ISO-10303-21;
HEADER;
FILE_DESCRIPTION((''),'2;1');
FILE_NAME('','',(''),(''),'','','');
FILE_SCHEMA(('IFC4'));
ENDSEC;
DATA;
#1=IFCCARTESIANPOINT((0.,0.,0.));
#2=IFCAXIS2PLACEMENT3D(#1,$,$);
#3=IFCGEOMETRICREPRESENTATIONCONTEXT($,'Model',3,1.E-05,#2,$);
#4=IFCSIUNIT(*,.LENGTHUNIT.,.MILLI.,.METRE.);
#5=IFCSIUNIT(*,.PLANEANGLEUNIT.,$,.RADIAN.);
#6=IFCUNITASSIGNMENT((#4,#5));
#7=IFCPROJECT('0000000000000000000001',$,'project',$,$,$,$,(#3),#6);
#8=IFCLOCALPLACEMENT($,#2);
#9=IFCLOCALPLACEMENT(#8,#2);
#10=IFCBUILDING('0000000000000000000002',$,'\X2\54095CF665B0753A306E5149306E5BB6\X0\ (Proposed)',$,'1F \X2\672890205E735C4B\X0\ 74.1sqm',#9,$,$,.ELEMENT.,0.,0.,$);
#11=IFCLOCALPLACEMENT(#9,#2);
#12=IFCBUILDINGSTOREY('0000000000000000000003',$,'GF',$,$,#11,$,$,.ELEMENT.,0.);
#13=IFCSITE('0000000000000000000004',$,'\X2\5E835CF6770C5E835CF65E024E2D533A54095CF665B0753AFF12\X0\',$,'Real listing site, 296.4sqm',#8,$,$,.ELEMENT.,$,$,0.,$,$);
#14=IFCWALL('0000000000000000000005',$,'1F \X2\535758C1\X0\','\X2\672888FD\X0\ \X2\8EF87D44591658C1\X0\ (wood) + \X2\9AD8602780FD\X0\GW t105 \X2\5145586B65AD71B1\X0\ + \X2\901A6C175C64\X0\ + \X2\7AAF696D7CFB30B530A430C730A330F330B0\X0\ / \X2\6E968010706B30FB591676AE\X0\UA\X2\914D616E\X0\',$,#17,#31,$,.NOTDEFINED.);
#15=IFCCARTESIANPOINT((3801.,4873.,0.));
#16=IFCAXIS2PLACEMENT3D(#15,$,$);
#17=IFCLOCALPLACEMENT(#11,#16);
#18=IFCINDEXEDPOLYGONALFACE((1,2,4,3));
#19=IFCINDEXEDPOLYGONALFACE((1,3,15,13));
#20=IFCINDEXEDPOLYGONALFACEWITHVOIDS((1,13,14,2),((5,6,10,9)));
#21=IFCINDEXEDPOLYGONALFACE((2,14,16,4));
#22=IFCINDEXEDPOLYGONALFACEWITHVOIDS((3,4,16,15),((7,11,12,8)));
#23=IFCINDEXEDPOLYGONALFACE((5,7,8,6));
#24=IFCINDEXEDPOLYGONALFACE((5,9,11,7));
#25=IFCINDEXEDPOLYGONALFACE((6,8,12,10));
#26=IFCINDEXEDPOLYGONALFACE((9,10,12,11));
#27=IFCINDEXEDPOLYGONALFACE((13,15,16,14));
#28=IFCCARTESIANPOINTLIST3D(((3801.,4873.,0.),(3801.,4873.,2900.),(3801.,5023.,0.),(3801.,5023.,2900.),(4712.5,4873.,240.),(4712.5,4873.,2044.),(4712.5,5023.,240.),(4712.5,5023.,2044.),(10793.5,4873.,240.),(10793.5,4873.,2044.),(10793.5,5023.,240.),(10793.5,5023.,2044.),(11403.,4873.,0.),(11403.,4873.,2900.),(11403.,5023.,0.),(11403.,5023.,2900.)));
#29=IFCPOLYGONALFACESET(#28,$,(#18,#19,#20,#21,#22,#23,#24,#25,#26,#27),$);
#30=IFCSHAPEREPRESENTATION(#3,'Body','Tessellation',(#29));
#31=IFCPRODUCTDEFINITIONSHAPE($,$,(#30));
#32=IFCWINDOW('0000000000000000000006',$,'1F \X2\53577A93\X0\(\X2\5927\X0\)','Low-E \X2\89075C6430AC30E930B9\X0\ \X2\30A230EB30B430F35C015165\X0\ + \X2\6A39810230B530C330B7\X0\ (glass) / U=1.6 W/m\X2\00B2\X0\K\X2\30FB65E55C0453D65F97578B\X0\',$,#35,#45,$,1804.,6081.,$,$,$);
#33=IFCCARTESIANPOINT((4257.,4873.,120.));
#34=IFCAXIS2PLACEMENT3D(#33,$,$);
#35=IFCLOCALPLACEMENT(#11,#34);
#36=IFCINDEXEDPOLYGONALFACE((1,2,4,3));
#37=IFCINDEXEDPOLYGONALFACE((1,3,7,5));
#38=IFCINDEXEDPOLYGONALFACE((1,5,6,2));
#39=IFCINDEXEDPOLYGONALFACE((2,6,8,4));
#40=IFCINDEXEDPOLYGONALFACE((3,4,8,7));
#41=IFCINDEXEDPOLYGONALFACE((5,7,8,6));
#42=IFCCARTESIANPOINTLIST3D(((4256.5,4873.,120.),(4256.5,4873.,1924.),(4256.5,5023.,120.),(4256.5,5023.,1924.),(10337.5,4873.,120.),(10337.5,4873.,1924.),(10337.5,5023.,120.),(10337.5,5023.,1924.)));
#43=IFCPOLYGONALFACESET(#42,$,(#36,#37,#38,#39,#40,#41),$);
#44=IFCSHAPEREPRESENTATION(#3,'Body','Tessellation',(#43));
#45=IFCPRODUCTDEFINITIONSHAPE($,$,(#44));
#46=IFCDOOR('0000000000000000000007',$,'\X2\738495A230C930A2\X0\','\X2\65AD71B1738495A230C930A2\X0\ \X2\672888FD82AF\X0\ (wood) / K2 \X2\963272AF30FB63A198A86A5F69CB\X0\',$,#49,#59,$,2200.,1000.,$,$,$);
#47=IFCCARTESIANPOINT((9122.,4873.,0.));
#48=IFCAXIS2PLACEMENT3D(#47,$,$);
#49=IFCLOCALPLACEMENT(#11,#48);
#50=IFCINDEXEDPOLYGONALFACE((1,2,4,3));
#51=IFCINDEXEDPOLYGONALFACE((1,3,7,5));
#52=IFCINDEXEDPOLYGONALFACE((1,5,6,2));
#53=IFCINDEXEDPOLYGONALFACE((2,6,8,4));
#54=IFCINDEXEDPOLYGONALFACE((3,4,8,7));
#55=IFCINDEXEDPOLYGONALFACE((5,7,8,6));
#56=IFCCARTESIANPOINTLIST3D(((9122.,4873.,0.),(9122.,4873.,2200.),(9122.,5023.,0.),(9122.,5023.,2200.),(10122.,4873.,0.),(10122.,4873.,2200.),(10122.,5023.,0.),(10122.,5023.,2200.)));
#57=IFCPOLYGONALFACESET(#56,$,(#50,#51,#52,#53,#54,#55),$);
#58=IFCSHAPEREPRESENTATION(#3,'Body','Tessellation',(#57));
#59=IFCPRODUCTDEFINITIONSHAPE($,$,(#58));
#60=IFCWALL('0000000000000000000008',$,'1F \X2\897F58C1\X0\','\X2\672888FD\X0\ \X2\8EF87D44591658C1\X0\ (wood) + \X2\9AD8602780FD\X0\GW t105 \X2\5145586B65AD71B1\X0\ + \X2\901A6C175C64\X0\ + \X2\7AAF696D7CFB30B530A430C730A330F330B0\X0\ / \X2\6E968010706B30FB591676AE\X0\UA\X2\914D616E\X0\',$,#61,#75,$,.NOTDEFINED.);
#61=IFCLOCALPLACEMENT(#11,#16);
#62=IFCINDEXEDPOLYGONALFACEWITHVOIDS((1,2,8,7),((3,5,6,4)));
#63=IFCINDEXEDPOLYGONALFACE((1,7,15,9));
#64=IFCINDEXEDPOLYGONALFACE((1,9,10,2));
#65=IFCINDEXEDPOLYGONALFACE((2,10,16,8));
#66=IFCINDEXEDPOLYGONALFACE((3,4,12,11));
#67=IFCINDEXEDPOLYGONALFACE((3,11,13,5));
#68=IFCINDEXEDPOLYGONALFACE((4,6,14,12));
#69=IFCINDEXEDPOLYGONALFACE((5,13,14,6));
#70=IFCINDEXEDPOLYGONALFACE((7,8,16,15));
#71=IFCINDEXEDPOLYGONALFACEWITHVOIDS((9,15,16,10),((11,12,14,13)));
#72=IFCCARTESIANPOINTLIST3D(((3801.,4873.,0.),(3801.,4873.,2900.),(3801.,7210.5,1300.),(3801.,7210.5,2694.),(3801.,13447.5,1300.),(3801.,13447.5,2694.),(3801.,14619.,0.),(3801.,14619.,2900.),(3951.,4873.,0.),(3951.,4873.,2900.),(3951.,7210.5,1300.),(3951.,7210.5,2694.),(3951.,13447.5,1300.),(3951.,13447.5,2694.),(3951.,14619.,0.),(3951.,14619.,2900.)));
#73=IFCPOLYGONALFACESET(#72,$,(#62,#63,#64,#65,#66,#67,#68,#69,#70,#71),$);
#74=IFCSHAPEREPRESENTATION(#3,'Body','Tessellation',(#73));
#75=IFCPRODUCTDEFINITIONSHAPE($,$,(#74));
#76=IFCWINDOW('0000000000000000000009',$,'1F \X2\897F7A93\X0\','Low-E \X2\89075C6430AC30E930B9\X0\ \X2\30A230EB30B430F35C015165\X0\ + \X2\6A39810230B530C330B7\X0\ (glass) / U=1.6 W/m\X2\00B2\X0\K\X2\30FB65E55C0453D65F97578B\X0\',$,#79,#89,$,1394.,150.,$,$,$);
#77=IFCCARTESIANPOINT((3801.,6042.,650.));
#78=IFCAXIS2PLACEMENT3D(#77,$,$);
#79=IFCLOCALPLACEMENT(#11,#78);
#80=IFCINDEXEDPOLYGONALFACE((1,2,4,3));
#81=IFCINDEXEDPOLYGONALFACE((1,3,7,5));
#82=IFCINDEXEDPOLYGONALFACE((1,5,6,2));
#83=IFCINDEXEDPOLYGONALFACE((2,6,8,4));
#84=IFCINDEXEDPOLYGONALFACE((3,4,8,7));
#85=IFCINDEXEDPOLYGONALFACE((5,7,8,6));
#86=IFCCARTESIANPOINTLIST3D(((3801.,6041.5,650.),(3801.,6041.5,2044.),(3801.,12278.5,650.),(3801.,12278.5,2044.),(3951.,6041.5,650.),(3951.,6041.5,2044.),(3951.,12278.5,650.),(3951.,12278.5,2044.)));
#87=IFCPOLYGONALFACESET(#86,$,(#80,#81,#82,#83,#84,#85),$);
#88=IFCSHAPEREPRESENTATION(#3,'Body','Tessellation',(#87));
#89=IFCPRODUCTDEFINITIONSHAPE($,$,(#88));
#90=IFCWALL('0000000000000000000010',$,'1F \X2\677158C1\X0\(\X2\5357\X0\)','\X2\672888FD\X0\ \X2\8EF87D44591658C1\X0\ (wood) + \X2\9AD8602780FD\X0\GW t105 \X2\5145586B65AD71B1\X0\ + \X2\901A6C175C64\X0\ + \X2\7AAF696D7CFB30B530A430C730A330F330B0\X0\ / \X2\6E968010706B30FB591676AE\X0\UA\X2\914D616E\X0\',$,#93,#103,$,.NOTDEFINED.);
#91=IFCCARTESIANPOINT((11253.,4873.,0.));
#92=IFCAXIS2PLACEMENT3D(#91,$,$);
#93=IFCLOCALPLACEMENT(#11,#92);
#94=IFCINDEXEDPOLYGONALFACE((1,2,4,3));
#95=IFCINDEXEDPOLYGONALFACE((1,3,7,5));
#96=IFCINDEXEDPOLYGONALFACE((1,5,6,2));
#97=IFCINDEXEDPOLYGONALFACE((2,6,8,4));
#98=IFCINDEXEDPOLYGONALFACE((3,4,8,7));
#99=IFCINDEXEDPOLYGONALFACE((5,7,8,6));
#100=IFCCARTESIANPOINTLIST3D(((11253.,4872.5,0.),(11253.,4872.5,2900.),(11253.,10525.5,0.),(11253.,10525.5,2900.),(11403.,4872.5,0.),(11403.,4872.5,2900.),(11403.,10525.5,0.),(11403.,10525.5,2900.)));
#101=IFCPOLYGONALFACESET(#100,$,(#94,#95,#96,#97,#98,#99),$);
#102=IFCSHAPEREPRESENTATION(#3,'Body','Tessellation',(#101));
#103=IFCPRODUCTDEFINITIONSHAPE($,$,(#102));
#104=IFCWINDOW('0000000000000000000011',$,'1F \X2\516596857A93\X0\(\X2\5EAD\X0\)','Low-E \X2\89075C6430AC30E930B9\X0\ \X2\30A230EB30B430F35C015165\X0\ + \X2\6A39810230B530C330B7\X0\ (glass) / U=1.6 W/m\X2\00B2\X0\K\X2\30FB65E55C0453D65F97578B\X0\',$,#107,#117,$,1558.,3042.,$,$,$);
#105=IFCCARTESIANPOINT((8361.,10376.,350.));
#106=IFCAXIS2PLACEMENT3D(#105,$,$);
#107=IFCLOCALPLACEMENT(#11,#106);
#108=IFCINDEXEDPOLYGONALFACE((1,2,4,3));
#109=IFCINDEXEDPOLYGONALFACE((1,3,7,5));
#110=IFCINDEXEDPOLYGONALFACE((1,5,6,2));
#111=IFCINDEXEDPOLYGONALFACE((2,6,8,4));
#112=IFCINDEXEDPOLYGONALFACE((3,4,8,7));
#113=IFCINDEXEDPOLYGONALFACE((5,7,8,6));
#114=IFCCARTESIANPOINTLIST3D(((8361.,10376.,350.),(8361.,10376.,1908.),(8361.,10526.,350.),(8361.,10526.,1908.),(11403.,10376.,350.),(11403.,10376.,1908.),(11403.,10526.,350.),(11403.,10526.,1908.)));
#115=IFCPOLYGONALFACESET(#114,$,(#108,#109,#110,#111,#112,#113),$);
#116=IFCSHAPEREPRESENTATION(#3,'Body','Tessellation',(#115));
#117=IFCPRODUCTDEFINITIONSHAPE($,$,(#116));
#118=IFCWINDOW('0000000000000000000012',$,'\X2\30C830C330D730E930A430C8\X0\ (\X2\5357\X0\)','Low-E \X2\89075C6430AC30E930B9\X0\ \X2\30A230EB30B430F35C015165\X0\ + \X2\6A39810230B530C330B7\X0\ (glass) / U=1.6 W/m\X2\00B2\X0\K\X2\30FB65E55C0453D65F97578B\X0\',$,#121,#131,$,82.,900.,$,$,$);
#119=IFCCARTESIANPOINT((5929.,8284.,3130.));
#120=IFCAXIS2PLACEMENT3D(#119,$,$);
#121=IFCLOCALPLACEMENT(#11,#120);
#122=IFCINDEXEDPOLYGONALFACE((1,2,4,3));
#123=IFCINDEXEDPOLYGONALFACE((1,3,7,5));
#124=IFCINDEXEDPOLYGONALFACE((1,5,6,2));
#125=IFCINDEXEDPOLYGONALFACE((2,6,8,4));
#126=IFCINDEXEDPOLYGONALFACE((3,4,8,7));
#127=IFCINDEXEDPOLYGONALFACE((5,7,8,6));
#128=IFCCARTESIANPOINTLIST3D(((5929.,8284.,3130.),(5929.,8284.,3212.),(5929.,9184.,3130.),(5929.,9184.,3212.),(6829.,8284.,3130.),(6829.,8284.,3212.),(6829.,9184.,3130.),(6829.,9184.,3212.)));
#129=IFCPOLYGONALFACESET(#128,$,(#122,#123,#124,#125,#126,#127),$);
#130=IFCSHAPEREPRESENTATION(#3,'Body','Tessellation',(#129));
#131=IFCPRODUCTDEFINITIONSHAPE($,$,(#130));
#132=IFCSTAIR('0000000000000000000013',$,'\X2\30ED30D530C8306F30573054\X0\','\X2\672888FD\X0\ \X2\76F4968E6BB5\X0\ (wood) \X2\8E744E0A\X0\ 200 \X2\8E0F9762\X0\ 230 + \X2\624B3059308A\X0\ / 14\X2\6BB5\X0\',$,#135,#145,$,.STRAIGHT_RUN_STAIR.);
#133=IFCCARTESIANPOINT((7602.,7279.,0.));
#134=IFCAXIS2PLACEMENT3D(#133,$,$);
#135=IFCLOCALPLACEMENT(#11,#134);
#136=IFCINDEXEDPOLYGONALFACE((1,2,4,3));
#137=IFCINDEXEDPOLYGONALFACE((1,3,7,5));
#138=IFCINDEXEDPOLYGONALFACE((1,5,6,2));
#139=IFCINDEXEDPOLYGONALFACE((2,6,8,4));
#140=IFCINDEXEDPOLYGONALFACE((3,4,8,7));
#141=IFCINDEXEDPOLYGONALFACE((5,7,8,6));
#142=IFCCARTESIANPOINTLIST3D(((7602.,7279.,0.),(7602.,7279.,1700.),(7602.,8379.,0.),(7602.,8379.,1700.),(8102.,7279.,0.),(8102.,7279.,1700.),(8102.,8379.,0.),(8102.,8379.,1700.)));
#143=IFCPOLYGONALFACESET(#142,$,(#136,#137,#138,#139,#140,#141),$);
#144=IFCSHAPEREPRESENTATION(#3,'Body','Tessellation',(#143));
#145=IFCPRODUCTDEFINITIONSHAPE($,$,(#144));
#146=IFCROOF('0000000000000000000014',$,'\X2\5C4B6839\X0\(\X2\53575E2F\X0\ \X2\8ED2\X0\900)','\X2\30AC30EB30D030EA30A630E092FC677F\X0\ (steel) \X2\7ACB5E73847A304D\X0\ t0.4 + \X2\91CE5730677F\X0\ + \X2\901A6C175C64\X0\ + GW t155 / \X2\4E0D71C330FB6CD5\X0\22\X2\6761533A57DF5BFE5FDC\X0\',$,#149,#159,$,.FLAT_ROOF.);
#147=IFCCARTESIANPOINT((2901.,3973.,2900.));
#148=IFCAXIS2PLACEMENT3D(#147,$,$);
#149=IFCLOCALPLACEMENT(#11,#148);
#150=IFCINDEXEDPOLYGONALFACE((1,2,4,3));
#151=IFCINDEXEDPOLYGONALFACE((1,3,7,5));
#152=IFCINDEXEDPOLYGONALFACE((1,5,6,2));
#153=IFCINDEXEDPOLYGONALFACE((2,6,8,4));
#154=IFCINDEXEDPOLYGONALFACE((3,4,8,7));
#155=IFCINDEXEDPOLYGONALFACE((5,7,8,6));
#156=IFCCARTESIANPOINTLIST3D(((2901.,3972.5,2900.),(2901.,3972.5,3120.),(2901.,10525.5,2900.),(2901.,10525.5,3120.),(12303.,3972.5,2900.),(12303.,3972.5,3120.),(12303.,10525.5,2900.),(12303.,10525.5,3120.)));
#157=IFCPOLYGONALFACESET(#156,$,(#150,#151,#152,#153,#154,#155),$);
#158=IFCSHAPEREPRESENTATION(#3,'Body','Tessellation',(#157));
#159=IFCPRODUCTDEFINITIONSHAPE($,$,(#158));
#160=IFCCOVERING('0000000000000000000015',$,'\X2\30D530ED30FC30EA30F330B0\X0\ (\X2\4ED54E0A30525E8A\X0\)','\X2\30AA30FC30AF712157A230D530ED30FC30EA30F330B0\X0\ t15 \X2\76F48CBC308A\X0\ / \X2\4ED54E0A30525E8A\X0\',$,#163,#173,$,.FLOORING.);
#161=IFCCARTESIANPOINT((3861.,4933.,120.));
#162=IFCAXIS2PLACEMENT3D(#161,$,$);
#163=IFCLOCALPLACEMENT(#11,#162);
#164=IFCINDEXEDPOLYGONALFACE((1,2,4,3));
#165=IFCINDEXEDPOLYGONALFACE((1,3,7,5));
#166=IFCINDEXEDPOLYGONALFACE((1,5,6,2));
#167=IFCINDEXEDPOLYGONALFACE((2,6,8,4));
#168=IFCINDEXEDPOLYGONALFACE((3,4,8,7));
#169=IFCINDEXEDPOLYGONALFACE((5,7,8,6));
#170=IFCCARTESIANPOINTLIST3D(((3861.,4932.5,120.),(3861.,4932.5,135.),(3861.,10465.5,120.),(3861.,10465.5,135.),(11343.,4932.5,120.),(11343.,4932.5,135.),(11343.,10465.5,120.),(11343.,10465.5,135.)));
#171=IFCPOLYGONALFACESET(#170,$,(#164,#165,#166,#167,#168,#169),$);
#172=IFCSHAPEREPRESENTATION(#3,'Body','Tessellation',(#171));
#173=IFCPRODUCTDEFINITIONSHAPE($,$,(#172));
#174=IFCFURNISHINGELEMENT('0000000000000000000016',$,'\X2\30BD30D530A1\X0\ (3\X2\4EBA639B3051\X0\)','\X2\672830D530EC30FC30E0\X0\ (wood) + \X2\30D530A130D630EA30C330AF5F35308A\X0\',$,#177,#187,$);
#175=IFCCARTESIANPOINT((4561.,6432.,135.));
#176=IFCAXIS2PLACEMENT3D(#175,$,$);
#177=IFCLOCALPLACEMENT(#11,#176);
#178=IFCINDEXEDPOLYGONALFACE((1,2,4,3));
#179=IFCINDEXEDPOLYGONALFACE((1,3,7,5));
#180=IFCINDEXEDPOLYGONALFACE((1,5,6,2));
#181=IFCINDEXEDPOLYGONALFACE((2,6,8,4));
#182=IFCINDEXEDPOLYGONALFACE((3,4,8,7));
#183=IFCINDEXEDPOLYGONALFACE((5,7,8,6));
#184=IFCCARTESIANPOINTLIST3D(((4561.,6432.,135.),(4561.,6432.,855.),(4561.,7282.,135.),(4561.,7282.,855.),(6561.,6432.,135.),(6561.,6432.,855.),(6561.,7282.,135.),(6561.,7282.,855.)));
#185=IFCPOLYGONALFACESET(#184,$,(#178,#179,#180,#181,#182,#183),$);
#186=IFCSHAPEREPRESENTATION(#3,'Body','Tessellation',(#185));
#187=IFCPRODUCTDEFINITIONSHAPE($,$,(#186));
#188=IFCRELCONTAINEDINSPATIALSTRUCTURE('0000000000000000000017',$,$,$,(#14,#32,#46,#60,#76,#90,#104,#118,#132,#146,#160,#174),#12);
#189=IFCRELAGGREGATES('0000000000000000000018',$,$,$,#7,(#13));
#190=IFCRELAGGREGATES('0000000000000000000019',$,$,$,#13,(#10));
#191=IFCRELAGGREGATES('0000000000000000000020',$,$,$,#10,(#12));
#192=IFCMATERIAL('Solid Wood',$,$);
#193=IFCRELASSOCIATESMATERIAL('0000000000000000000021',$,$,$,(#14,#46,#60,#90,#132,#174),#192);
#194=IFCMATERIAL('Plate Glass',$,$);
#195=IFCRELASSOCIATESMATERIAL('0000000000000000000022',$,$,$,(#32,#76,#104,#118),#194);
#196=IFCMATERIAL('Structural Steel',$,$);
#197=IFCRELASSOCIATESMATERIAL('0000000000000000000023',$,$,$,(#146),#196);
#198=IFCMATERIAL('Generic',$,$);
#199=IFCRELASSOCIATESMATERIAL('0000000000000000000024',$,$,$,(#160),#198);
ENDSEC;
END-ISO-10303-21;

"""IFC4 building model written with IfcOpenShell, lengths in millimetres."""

from ifc_helpers import new_model, si_unit, frame, frame_2d, origin, place, context, project, spatial, rectangle, extrude, material, element, fill, save


model = new_model("IFC4")

# Units and contexts
model_context = context("Model", 3, precision=1e-05, world=origin())
ifc_project = project(units=[si_unit("LENGTHUNIT", "METRE", prefix="MILLI"), si_unit("PLANEANGLEUNIT", "RADIAN")], contexts=[model_context])

# Site, building, storey
site_placement = place(None, origin())
site = spatial("IfcSite", under=ifc_project, at=site_placement, Name="広島県広島市中区吉島新町２", ObjectType="Real listing site, 296.4sqm", CompositionType="ELEMENT", RefElevation=0.0)
building_placement = place(site_placement, origin())
building = spatial("IfcBuilding", under=site, at=building_placement, Name="吉島新町の光の家 (Proposed)", ObjectType="1F 木造平屋 74.1sqm", CompositionType="ELEMENT", ElevationOfRefHeight=0.0, ElevationOfTerrain=0.0)
storey_placement = place(building_placement, origin())
storey = spatial("IfcBuildingStorey", under=building, at=storey_placement, Name="GF", CompositionType="ELEMENT", Elevation=0.0)

# Shared definitions
ifc_material_1 = material(Name="Solid Wood")

# Wall, openings, window, door
wall_1_placement = place(storey_placement, frame((3801.0, 4873.0, 0.0)))
wall_1 = element("IfcWall", 1, at=wall_1_placement, inside=storey, material=ifc_material_1, Name="1F 南壁", Description="木製 軸組外壁 (wood) + 高性能GW t105 充填断熱 + 通気層 + 窯業系サイディング / 準耐火・外皮UA配慮", PredefinedType="NOTDEFINED", context=model_context, shape_type="SweptSolid", body=[
    extrude(rectangle(XDim=7602.0, YDim=150.0, at=frame_2d((3801.0, 75.0))), frame((3801.0, 4873.0, 0.0)), (0.0, 0.0, 1.0), 2900.0),
])
opening_1_placement = place(storey_placement, frame((4257.0, 4873.0, 120.0)))
opening_1 = element("IfcOpeningElement", 2, at=opening_1_placement, cuts=wall_1, PredefinedType="NOTDEFINED", context=model_context, shape_type="SweptSolid", body=[
    extrude(rectangle(XDim=6081.0, YDim=150.0, at=frame_2d((3040.0, 75.0))), frame((4257.0, 4873.0, 120.0)), (0.0, 0.0, 1.0), 1804.0),
])
opening_2_placement = place(storey_placement, frame((9122.0, 4873.0, 0.0)))
opening_2 = element("IfcOpeningElement", 3, at=opening_2_placement, cuts=wall_1, PredefinedType="NOTDEFINED", context=model_context, shape_type="SweptSolid", body=[
    extrude(rectangle(XDim=1000.0, YDim=150.0, at=frame_2d((500.0, 75.0))), frame((9122.0, 4873.0, 0.0)), (0.0, 0.0, 1.0), 2200.0),
])
ifc_material_2 = material(Name="Plate Glass")
window_1_placement = place(storey_placement, frame((4257.0, 4873.0, 120.0)))
window_1 = element("IfcWindow", 4, at=window_1_placement, inside=storey, material=ifc_material_2, Name="1F 南窓(大)", Description="Low-E 複層ガラス アルゴン封入 + 樹脂サッシ (glass) / U=1.6 W/m²K・日射取得型", OverallHeight=1804.0, OverallWidth=6081.0, context=model_context, shape_type="SweptSolid", body=[
    extrude(rectangle(XDim=6081.0, YDim=150.0, at=frame_2d((3040.0, 75.0))), frame((4257.0, 4873.0, 120.0)), (0.0, 0.0, 1.0), 1804.0),
])
fill(opening_1, window_1)
door_1_placement = place(storey_placement, frame((9122.0, 4873.0, 0.0)))
door_1 = element("IfcDoor", 5, at=door_1_placement, inside=storey, material=ifc_material_1, Name="玄関ドア", Description="断熱玄関ドア 木製芯 (wood) / K2 防犯・採風機構", OverallHeight=2200.0, OverallWidth=1000.0, context=model_context, shape_type="SweptSolid", body=[
    extrude(rectangle(XDim=1000.0, YDim=150.0, at=frame_2d((500.0, 75.0))), frame((9122.0, 4873.0, 0.0)), (0.0, 0.0, 1.0), 2200.0),
])
fill(opening_2, door_1)

# Walls, openings, windows
wall_2_placement = place(storey_placement, frame((3801.0, 4873.0, 0.0)))
wall_2 = element("IfcWall", 6, at=wall_2_placement, inside=storey, material=ifc_material_1, Name="1F 西壁", Description="木製 軸組外壁 (wood) + 高性能GW t105 充填断熱 + 通気層 + 窯業系サイディング / 準耐火・外皮UA配慮", PredefinedType="NOTDEFINED", context=model_context, shape_type="SweptSolid", body=[
    extrude(rectangle(XDim=150.0, YDim=9746.0, at=frame_2d((75.0, 4873.0))), frame((3801.0, 4873.0, 0.0)), (0.0, 0.0, 1.0), 2900.0),
])
opening_3_placement = place(storey_placement, frame((3801.0, 6042.0, 650.0)))
opening_3 = element("IfcOpeningElement", 7, at=opening_3_placement, cuts=wall_2, PredefinedType="NOTDEFINED", context=model_context, shape_type="SweptSolid", body=[
    extrude(rectangle(XDim=150.0, YDim=6237.0, at=frame_2d((75.0, 3118.0))), frame((3801.0, 6042.0, 650.0)), (0.0, 0.0, 1.0), 1394.0),
])
window_2_placement = place(storey_placement, frame((3801.0, 6042.0, 650.0)))
window_2 = element("IfcWindow", 8, at=window_2_placement, inside=storey, material=ifc_material_2, Name="1F 西窓", Description="Low-E 複層ガラス アルゴン封入 + 樹脂サッシ (glass) / U=1.6 W/m²K・日射取得型", OverallHeight=1394.0, OverallWidth=150.0, context=model_context, shape_type="SweptSolid", body=[
    extrude(rectangle(XDim=150.0, YDim=6237.0, at=frame_2d((75.0, 3118.0))), frame((3801.0, 6042.0, 650.0)), (0.0, 0.0, 1.0), 1394.0),
])
fill(opening_3, window_2)
wall_3_placement = place(storey_placement, frame((11253.0, 4873.0, 0.0)))
wall_3 = element("IfcWall", 9, at=wall_3_placement, inside=storey, material=ifc_material_1, Name="1F 東壁(南)", Description="木製 軸組外壁 (wood) + 高性能GW t105 充填断熱 + 通気層 + 窯業系サイディング / 準耐火・外皮UA配慮", PredefinedType="NOTDEFINED", context=model_context, shape_type="SweptSolid", body=[
    extrude(rectangle(XDim=150.0, YDim=5653.0, at=frame_2d((75.0, 2826.0))), frame((11253.0, 4873.0, 0.0)), (0.0, 0.0, 1.0), 2900.0),
])
opening_4_placement = place(storey_placement, frame((8361.0, 10376.0, 350.0)))
opening_4 = element("IfcOpeningElement", 10, at=opening_4_placement, cuts=wall_3, PredefinedType="NOTDEFINED", context=model_context, shape_type="SweptSolid", body=[
    extrude(rectangle(XDim=3042.0, YDim=150.0, at=frame_2d((1521.0, 75.0))), frame((8361.0, 10376.0, 350.0)), (0.0, 0.0, 1.0), 1558.0),
])
window_3_placement = place(storey_placement, frame((8361.0, 10376.0, 350.0)))
window_3 = element("IfcWindow", 11, at=window_3_placement, inside=storey, material=ifc_material_2, Name="1F 入隅窓(庭)", Description="Low-E 複層ガラス アルゴン封入 + 樹脂サッシ (glass) / U=1.6 W/m²K・日射取得型", OverallHeight=1558.0, OverallWidth=3042.0, context=model_context, shape_type="SweptSolid", body=[
    extrude(rectangle(XDim=3042.0, YDim=150.0, at=frame_2d((1521.0, 75.0))), frame((8361.0, 10376.0, 350.0)), (0.0, 0.0, 1.0), 1558.0),
])
fill(opening_4, window_3)

# Window
window_4_placement = place(storey_placement, frame((5929.0, 8284.0, 3130.0)))
element("IfcWindow", 12, at=window_4_placement, inside=storey, material=ifc_material_2, Name="トップライト (南)", Description="Low-E 複層ガラス アルゴン封入 + 樹脂サッシ (glass) / U=1.6 W/m²K・日射取得型", OverallHeight=82.0, OverallWidth=900.0, context=model_context, shape_type="SweptSolid", body=[
    extrude(rectangle(XDim=900.0, YDim=900.0, at=frame_2d((450.0, 450.0))), frame((5929.0, 8284.0, 3130.0)), (0.0, 0.0, 1.0), 82.0),
])

# Stair
stair_placement = place(storey_placement, frame((7602.0, 7279.0, 0.0)))
element("IfcStair", 13, at=stair_placement, inside=storey, material=ifc_material_1, Name="ロフトはしご", Description="木製 直階段 (wood) 蹴上 200 踏面 230 + 手すり / 14段", PredefinedType="STRAIGHT_RUN_STAIR", context=model_context, shape_type="SweptSolid", body=[
    extrude(rectangle(XDim=500.0, YDim=1100.0, at=frame_2d((250.0, 550.0))), frame((7602.0, 7279.0, 0.0)), (0.0, 0.0, 1.0), 1700.0),
])

# Roof
ifc_material_3 = material(Name="Structural Steel")
roof_placement = place(storey_placement, frame((2901.0, 3973.0, 2900.0)))
element("IfcRoof", 14, at=roof_placement, inside=storey, material=ifc_material_3, Name="屋根(南帯 軒900)", Description="ガルバリウム鋼板 (steel) 立平葺き t0.4 + 野地板 + 通気層 + GW t155 / 不燃・法22条区域対応", PredefinedType="FLAT_ROOF", context=model_context, shape_type="SweptSolid", body=[
    extrude(rectangle(XDim=9402.0, YDim=6553.0, at=frame_2d((4701.0, 3276.0))), frame((2901.0, 3973.0, 2900.0)), (0.0, 0.0, 1.0), 220.0),
])

# Covering
ifc_material_4 = material(Name="Generic")
covering_placement = place(storey_placement, frame((3861.0, 4933.0, 120.0)))
element("IfcCovering", 15, at=covering_placement, inside=storey, material=ifc_material_4, Name="フローリング (仕上げ床)", Description="オーク無垢フローリング t15 直貼り / 仕上げ床", PredefinedType="FLOORING", context=model_context, shape_type="SweptSolid", body=[
    extrude(rectangle(XDim=7482.0, YDim=5533.0, at=frame_2d((3741.0, 2766.0))), frame((3861.0, 4933.0, 120.0)), (0.0, 0.0, 1.0), 15.0),
])

# Furnishing element
furnishing_1_placement = place(storey_placement, frame((4561.0, 6432.0, 135.0)))
element("IfcFurnishingElement", 16, at=furnishing_1_placement, inside=storey, material=ifc_material_1, Name="ソファ (3人掛け)", Description="木フレーム (wood) + ファブリック張り", context=model_context, shape_type="SweptSolid", body=[
    extrude(rectangle(XDim=2000.0, YDim=850.0, at=frame_2d((1000.0, 425.0))), frame((4561.0, 6432.0, 135.0)), (0.0, 0.0, 1.0), 720.0),
])

save(model, "model.ifc")
